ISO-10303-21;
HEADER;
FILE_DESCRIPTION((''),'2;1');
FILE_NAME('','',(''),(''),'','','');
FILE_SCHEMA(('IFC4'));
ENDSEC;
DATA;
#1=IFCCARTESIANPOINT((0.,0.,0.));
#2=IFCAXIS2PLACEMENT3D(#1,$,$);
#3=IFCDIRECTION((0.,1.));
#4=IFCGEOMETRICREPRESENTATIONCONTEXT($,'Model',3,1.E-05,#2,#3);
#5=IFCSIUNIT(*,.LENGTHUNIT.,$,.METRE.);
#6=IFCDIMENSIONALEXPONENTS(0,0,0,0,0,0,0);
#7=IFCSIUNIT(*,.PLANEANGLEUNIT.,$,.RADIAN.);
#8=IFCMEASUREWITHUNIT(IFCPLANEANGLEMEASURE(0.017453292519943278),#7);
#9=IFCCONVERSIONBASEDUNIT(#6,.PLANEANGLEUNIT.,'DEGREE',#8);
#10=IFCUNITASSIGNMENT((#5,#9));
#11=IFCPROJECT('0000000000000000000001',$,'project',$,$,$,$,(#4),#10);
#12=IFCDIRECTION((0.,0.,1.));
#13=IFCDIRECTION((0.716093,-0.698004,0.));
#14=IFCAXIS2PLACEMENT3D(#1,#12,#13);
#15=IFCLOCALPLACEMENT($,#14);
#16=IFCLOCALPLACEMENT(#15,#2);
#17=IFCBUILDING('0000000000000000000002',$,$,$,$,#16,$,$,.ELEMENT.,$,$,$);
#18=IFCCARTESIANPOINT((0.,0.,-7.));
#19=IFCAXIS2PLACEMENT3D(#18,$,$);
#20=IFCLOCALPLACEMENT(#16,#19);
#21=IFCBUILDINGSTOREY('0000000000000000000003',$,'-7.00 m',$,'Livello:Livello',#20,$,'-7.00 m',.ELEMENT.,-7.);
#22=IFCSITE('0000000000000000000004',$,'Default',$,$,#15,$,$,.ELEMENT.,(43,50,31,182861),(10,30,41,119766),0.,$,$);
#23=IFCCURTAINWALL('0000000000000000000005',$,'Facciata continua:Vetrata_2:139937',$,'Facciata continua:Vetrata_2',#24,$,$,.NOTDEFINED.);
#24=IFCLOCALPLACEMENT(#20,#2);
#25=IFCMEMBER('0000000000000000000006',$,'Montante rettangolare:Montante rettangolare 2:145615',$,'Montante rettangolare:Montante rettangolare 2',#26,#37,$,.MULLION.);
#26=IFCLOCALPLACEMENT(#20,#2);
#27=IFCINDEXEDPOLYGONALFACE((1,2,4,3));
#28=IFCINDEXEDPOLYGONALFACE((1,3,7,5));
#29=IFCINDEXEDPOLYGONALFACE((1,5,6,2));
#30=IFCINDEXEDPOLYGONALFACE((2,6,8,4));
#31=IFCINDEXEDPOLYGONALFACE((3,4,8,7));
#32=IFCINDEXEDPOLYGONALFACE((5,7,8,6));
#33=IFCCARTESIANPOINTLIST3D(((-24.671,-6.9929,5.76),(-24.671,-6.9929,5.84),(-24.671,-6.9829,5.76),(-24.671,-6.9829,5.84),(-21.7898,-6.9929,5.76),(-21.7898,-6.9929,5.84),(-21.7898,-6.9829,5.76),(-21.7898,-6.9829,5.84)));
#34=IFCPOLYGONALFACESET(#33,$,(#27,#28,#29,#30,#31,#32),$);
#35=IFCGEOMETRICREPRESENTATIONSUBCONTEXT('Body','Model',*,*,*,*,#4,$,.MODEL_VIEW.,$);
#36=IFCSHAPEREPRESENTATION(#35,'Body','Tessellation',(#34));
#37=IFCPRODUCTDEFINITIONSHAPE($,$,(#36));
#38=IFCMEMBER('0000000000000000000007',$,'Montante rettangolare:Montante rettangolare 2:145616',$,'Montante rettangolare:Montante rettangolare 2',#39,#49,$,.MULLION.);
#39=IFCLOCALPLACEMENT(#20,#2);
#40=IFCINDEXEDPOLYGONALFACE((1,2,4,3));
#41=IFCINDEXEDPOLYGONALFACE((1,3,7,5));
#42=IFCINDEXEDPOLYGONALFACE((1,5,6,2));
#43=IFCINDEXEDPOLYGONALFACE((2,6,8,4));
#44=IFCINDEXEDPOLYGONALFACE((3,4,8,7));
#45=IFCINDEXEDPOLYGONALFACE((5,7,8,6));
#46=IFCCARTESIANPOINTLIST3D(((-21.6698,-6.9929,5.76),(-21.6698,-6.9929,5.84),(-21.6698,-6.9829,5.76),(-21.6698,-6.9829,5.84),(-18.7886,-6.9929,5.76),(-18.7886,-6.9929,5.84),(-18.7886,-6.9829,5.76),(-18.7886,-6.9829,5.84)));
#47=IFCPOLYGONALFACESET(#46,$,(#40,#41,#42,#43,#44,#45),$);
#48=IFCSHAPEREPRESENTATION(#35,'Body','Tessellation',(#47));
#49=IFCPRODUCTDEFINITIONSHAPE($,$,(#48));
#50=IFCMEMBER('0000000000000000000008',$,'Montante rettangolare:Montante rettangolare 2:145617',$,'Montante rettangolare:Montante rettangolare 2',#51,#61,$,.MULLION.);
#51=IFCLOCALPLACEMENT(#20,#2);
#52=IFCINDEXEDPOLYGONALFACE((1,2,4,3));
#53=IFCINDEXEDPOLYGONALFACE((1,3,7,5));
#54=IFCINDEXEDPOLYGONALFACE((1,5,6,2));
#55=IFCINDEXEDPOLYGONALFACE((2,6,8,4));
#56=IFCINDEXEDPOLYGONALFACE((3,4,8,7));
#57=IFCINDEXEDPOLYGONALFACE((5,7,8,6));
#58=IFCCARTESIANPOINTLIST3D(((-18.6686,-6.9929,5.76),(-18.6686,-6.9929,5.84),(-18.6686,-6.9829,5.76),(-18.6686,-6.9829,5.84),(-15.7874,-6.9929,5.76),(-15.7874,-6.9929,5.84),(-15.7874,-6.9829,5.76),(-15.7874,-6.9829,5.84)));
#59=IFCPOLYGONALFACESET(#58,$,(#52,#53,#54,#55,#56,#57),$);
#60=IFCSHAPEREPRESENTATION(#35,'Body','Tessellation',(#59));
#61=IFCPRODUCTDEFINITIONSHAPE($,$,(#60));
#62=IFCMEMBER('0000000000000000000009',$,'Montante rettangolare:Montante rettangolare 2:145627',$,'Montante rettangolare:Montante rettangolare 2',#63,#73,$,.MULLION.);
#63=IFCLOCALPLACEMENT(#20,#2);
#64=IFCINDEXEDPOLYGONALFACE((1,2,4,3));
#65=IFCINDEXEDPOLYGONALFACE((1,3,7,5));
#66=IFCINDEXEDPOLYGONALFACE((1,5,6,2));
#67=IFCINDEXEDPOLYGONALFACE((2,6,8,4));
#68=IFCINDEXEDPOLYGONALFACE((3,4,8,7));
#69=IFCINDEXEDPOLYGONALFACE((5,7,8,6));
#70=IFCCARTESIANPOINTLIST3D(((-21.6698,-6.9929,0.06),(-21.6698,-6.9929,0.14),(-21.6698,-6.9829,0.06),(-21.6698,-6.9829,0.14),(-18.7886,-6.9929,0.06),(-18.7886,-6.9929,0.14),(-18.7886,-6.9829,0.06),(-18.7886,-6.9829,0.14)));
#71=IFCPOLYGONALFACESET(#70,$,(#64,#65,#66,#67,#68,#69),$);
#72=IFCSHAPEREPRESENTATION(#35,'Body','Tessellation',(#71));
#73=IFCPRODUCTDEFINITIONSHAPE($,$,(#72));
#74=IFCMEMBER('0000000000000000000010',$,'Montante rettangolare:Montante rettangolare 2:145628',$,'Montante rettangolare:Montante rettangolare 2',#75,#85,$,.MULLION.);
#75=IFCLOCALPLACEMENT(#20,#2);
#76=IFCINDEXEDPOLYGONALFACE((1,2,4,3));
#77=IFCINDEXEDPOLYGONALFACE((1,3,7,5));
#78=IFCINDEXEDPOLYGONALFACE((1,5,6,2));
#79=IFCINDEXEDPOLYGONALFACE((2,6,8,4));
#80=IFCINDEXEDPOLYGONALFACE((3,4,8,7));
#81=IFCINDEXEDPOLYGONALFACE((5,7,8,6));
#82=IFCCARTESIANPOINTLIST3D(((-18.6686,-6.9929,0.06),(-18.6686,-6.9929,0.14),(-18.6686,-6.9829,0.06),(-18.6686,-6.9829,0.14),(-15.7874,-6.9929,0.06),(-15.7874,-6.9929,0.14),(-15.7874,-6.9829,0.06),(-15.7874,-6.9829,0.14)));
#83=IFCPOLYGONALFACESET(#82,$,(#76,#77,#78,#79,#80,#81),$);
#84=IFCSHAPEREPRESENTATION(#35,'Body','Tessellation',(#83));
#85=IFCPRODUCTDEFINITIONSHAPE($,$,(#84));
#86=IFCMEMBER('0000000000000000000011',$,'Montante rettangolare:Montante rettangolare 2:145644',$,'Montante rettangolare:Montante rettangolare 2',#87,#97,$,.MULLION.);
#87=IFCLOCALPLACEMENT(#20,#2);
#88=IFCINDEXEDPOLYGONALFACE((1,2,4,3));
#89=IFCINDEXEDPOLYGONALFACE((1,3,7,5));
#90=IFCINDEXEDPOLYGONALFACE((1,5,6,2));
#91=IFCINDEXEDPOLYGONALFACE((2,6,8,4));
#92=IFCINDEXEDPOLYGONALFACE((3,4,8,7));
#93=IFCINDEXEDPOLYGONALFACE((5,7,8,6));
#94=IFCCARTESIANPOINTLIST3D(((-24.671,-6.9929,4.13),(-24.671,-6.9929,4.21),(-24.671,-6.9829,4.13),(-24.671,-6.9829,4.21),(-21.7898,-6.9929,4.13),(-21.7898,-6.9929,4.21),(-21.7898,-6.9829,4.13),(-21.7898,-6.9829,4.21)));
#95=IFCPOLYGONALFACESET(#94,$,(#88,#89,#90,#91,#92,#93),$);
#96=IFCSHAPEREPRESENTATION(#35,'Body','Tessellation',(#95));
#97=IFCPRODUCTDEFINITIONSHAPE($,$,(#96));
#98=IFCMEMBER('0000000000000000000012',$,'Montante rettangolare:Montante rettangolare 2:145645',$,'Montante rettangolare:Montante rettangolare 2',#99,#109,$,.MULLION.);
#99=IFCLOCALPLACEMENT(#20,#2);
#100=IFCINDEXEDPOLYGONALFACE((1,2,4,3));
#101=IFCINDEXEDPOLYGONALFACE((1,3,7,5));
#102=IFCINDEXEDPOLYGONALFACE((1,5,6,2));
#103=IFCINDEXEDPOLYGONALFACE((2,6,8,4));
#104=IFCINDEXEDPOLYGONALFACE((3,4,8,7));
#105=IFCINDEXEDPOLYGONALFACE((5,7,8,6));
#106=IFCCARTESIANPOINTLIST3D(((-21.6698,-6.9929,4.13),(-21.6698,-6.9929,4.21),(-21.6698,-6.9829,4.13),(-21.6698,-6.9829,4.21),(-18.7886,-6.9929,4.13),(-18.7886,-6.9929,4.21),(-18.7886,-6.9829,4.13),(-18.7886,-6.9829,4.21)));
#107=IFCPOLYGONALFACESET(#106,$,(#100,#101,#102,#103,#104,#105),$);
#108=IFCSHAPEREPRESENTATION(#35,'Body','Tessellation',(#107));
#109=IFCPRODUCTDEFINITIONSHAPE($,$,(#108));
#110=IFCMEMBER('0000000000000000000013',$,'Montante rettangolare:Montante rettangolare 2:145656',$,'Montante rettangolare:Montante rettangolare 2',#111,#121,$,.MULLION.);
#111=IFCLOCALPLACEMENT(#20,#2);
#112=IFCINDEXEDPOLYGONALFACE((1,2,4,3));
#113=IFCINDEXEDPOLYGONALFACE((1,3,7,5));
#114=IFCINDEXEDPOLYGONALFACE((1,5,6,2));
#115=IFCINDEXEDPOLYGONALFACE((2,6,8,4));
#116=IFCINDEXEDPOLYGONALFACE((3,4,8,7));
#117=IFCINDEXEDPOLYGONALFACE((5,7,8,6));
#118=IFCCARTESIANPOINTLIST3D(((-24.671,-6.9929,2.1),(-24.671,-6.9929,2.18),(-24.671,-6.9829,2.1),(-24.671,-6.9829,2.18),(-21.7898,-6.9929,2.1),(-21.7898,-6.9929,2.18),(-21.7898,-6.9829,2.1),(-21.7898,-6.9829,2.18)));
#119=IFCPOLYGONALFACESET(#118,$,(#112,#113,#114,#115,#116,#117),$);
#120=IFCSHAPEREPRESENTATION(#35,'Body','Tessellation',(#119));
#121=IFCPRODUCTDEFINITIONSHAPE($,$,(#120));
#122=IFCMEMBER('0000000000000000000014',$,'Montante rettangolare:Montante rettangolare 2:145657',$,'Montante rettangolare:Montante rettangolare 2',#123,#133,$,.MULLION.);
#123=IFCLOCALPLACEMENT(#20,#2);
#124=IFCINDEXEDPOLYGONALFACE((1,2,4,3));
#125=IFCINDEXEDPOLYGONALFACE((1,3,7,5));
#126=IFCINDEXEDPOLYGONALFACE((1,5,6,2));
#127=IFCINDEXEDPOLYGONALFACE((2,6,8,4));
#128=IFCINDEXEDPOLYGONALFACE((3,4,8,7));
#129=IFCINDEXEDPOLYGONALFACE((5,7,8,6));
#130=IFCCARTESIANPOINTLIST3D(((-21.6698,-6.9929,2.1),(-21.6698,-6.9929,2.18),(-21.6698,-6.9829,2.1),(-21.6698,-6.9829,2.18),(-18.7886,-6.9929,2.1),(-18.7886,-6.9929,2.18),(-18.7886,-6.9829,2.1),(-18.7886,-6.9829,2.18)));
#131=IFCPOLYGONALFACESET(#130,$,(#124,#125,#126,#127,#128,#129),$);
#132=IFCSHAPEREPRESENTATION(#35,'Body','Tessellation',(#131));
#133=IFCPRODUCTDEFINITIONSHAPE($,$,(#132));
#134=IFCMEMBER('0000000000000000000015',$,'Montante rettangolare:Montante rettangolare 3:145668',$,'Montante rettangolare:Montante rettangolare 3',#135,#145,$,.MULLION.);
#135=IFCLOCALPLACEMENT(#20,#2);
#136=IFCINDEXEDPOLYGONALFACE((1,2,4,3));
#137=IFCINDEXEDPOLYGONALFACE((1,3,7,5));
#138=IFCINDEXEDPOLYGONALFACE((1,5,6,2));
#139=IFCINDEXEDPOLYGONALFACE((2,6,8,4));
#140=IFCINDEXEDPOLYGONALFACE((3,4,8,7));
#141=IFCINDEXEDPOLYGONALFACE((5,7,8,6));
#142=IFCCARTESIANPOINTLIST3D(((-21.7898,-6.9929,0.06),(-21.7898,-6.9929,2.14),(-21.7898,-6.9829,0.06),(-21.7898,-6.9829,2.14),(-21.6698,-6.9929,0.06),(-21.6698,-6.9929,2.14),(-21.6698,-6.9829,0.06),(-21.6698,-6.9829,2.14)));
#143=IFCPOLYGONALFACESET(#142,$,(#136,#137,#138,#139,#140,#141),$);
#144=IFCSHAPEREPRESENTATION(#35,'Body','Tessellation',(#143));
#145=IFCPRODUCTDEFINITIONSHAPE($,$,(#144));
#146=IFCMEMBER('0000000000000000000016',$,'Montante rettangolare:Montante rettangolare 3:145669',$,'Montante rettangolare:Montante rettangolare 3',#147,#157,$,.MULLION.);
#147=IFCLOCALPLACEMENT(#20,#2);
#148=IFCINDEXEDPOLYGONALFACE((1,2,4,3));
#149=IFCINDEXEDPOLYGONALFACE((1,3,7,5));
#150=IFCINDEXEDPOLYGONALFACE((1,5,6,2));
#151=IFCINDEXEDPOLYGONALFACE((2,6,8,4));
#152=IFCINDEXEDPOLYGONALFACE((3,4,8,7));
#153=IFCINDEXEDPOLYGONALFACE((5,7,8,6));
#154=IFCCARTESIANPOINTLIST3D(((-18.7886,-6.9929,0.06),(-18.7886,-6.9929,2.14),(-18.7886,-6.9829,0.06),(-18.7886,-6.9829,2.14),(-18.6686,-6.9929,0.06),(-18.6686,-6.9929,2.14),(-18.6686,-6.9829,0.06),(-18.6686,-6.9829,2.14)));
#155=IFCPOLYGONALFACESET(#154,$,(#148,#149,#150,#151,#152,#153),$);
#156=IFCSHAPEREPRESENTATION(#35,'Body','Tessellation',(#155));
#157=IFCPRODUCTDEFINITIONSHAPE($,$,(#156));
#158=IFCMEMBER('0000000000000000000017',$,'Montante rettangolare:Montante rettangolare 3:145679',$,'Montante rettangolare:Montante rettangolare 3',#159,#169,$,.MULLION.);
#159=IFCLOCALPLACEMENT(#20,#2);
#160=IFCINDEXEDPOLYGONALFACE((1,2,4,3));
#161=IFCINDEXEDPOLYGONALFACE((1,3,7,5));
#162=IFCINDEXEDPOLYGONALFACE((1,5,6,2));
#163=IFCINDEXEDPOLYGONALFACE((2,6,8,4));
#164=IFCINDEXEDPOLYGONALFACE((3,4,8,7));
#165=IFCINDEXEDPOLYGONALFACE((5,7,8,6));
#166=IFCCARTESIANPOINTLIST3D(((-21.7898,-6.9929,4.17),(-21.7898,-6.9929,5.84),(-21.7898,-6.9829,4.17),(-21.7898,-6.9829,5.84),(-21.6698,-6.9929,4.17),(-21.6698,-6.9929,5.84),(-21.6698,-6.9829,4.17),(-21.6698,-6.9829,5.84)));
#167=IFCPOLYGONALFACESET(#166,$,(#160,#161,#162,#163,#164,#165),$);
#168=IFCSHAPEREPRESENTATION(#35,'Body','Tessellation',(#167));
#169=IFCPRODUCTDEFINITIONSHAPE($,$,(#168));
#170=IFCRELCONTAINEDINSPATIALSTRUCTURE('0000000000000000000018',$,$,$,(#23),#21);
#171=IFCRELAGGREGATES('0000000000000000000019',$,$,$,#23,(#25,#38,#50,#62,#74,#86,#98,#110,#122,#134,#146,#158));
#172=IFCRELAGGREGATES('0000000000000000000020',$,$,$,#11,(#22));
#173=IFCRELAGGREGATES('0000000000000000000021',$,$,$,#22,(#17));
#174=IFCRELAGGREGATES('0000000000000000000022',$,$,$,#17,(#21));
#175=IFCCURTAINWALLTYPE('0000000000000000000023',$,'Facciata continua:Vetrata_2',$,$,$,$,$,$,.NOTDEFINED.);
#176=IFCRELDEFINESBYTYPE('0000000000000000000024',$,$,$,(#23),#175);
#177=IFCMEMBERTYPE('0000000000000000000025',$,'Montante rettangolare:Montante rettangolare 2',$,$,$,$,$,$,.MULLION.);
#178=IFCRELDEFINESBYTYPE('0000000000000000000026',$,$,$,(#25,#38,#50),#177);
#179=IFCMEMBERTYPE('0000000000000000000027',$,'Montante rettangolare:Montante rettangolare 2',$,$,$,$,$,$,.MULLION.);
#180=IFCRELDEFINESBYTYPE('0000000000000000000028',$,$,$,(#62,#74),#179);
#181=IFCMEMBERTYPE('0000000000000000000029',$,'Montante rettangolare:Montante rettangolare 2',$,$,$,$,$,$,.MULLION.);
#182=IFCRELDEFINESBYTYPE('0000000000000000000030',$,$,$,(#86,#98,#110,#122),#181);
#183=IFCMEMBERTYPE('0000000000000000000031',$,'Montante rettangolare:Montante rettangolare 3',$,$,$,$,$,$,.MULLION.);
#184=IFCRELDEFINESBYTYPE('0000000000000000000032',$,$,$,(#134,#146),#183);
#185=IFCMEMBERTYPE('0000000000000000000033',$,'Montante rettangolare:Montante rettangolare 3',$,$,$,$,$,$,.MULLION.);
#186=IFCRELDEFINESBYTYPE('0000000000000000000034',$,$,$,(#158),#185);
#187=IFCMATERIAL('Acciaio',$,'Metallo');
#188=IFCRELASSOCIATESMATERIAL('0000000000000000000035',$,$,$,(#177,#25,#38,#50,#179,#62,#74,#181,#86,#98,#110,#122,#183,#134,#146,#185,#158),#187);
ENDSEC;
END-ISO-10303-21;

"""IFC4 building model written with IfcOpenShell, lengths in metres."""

from ifc_helpers import new_model, entity, si_unit, converted_unit, direction, frame, origin, place, context, subcontext, project, spatial, indexed_curve, outline, extrude, source, transform, mapped, material, type_object, type_shapes, element, aggregate, save


model = new_model("IFC4")

# Units and contexts
model_context = context("Model", 3, precision=1e-05, world=origin(), true_north=direction((0.0, 1.0)))
body_context = subcontext(model_context, "Body", "Model", "MODEL_VIEW")
ifc_project = project(units=[si_unit("LENGTHUNIT", "METRE"), converted_unit("PLANEANGLEUNIT", "DEGREE", entity("IfcPlaneAngleMeasure", 0.017453292519943278), si_unit("PLANEANGLEUNIT", "RADIAN"), dimensions=[0, 0, 0, 0, 0, 0, 0])], contexts=[model_context])

# Site, building, storey
site_placement = place(None, frame((0.0, 0.0, 0.0), z_axis=(0.0, 0.0, 1.0), x_axis=(0.716093, -0.698004, 0.0)))
site = spatial("IfcSite", under=ifc_project, at=site_placement, Name="Default", CompositionType="ELEMENT", RefLatitude=(43, 50, 31, 182861), RefLongitude=(10, 30, 41, 119766), RefElevation=0.0)
building_placement = place(site_placement, origin())
building = spatial("IfcBuilding", under=site, at=building_placement, CompositionType="ELEMENT")
storey_placement = place(building_placement, frame((0.0, 0.0, -7.0)))
storey = spatial("IfcBuildingStorey", under=building, at=storey_placement, Name="-7.00 m", ObjectType="Livello:Livello", LongName="-7.00 m", CompositionType="ELEMENT", Elevation=-7.0)

# Curtain wall, members
curtain_wall_type = type_object("IfcCurtainWallType", Name="Facciata continua:Vetrata_2", PredefinedType="NOTDEFINED")
curtain_wall_placement = place(storey_placement, frame((0.0, 0.0, 7.0)))
curtain_wall = element("IfcCurtainWall", 1, at=curtain_wall_placement, inside=storey, type_object=curtain_wall_type, Name="Facciata continua:Vetrata_2:139937", ObjectType="Facciata continua:Vetrata_2", PredefinedType="NOTDEFINED")
ifc_material_1 = material(Name="Acciaio", Category="Metallo")
member_type_1 = type_object("IfcMemberType", Name="Montante rettangolare:Montante rettangolare 2", PredefinedType="MULLION", material=ifc_material_1)
shared_shape_1 = source(origin(), body_context, "Body", "SweptSolid", [
    extrude(outline(indexed_curve([(-0.04, -0.005), (0.04, -0.005), (0.04, 0.005), (-0.04, 0.005), (-0.04, -0.005)], self_intersect=False)), frame((-0.04, 0.01, -2.8812), z_axis=(0.0, 0.0, 1.0), x_axis=(-1.0, 0.0, 0.0)), (0.0, 0.0, 1.0), 2.8812),
])
type_shapes(member_type_1, [shared_shape_1])
member_1_placement = place(curtain_wall_placement, frame((-21.7898, -6.9779, -1.16), z_axis=(1.0, 0.0, 0.0), x_axis=(0.0, 0.0, 1.0)))
member_1 = element("IfcMember", 2, at=member_1_placement, type_object=member_type_1, material=ifc_material_1, Name="Montante rettangolare:Montante rettangolare 2:145615", ObjectType="Montante rettangolare:Montante rettangolare 2", PredefinedType="MULLION", context=body_context, shape_type="MappedRepresentation", body=[
    mapped(shared_shape_1, transform((0.0, 0.0, 0.0), scale=1.0)),
])
member_2_placement = place(curtain_wall_placement, frame((-18.7886, -6.9779, -1.16), z_axis=(1.0, 0.0, 0.0), x_axis=(0.0, 0.0, 1.0)))
member_2 = element("IfcMember", 3, at=member_2_placement, type_object=member_type_1, material=ifc_material_1, Name="Montante rettangolare:Montante rettangolare 2:145616", ObjectType="Montante rettangolare:Montante rettangolare 2", PredefinedType="MULLION", context=body_context, shape_type="MappedRepresentation", body=[
    mapped(shared_shape_1, transform((0.0, 0.0, 0.0), scale=1.0)),
])
member_3_placement = place(curtain_wall_placement, frame((-15.7874, -6.9779, -1.16), z_axis=(1.0, 0.0, 0.0), x_axis=(0.0, 0.0, 1.0)))
member_3 = element("IfcMember", 4, at=member_3_placement, type_object=member_type_1, material=ifc_material_1, Name="Montante rettangolare:Montante rettangolare 2:145617", ObjectType="Montante rettangolare:Montante rettangolare 2", PredefinedType="MULLION", context=body_context, shape_type="MappedRepresentation", body=[
    mapped(shared_shape_1, transform((0.0, 0.0, 0.0), scale=1.0)),
])
member_type_2 = type_object("IfcMemberType", Name="Montante rettangolare:Montante rettangolare 2", PredefinedType="MULLION", material=ifc_material_1)
shared_shape_2 = source(origin(), body_context, "Body", "SweptSolid", [
    extrude(outline(indexed_curve([(-0.04, -0.005), (0.04, -0.005), (0.04, 0.005), (-0.04, 0.005), (-0.04, -0.005)], self_intersect=False)), frame((-0.04, 0.01, -2.8812), z_axis=(0.0, 0.0, 1.0), x_axis=(-1.0, 0.0, 0.0)), (0.0, 0.0, 1.0), 2.8812),
])
type_shapes(member_type_2, [shared_shape_2])
member_4_placement = place(curtain_wall_placement, frame((-21.6698, -6.9779, -6.94), z_axis=(-1.0, 0.0, 0.0), x_axis=(0.0, 0.0, -1.0)))
member_4 = element("IfcMember", 5, at=member_4_placement, type_object=member_type_2, material=ifc_material_1, Name="Montante rettangolare:Montante rettangolare 2:145627", ObjectType="Montante rettangolare:Montante rettangolare 2", PredefinedType="MULLION", context=body_context, shape_type="MappedRepresentation", body=[
    mapped(shared_shape_2, transform((0.0, 0.0, 0.0), scale=1.0)),
])
member_5_placement = place(curtain_wall_placement, frame((-18.6686, -6.9779, -6.94), z_axis=(-1.0, 0.0, 0.0), x_axis=(0.0, 0.0, -1.0)))
member_5 = element("IfcMember", 6, at=member_5_placement, type_object=member_type_2, material=ifc_material_1, Name="Montante rettangolare:Montante rettangolare 2:145628", ObjectType="Montante rettangolare:Montante rettangolare 2", PredefinedType="MULLION", context=body_context, shape_type="MappedRepresentation", body=[
    mapped(shared_shape_2, transform((0.0, 0.0, 0.0), scale=1.0)),
])
member_type_3 = type_object("IfcMemberType", Name="Montante rettangolare:Montante rettangolare 2", PredefinedType="MULLION", material=ifc_material_1)
shared_shape_3 = source(origin(), body_context, "Body", "SweptSolid", [
    extrude(outline(indexed_curve([(-0.04, -0.005), (0.04, -0.005), (0.04, 0.005), (-0.04, 0.005), (-0.04, -0.005)], self_intersect=False)), frame((0.0, 0.01, -2.8812), z_axis=(0.0, 0.0, 1.0), x_axis=(-1.0, 0.0, 0.0)), (0.0, 0.0, 1.0), 2.8812),
])
type_shapes(member_type_3, [shared_shape_3])
member_6_placement = place(curtain_wall_placement, frame((-21.7898, -6.9779, -2.83), z_axis=(1.0, 0.0, 0.0), x_axis=(0.0, 0.0, 1.0)))
member_6 = element("IfcMember", 7, at=member_6_placement, type_object=member_type_3, material=ifc_material_1, Name="Montante rettangolare:Montante rettangolare 2:145644", ObjectType="Montante rettangolare:Montante rettangolare 2", PredefinedType="MULLION", context=body_context, shape_type="MappedRepresentation", body=[
    mapped(shared_shape_3, transform((0.0, 0.0, 0.0), scale=1.0)),
])
member_7_placement = place(curtain_wall_placement, frame((-18.7886, -6.9779, -2.83), z_axis=(1.0, 0.0, 0.0), x_axis=(0.0, 0.0, 1.0)))
member_7 = element("IfcMember", 8, at=member_7_placement, type_object=member_type_3, material=ifc_material_1, Name="Montante rettangolare:Montante rettangolare 2:145645", ObjectType="Montante rettangolare:Montante rettangolare 2", PredefinedType="MULLION", context=body_context, shape_type="MappedRepresentation", body=[
    mapped(shared_shape_3, transform((0.0, 0.0, 0.0), scale=1.0)),
])
member_8_placement = place(curtain_wall_placement, frame((-21.7898, -6.9779, -4.86), z_axis=(1.0, 0.0, 0.0), x_axis=(0.0, 0.0, 1.0)))
member_8 = element("IfcMember", 9, at=member_8_placement, type_object=member_type_3, material=ifc_material_1, Name="Montante rettangolare:Montante rettangolare 2:145656", ObjectType="Montante rettangolare:Montante rettangolare 2", PredefinedType="MULLION", context=body_context, shape_type="MappedRepresentation", body=[
    mapped(shared_shape_3, transform((0.0, 0.0, 0.0), scale=1.0)),
])
member_9_placement = place(curtain_wall_placement, frame((-18.7886, -6.9779, -4.86), z_axis=(1.0, 0.0, 0.0), x_axis=(0.0, 0.0, 1.0)))
member_9 = element("IfcMember", 10, at=member_9_placement, type_object=member_type_3, material=ifc_material_1, Name="Montante rettangolare:Montante rettangolare 2:145657", ObjectType="Montante rettangolare:Montante rettangolare 2", PredefinedType="MULLION", context=body_context, shape_type="MappedRepresentation", body=[
    mapped(shared_shape_3, transform((0.0, 0.0, 0.0), scale=1.0)),
])
member_type_4 = type_object("IfcMemberType", Name="Montante rettangolare:Montante rettangolare 3", PredefinedType="MULLION", material=ifc_material_1)
shared_shape_4 = source(origin(), body_context, "Body", "SweptSolid", [
    extrude(outline(indexed_curve([(-0.06, -0.005), (0.06, -0.005), (0.06, 0.005), (-0.06, 0.005), (-0.06, -0.005)], self_intersect=False)), frame((0.0, 0.01, -2.08), z_axis=(0.0, 0.0, 1.0), x_axis=(-1.0, 0.0, 0.0)), (0.0, 0.0, 1.0), 2.08),
])
type_shapes(member_type_4, [shared_shape_4])
member_10_placement = place(curtain_wall_placement, frame((-21.7298, -6.9779, -6.94), z_axis=(0.0, 0.0, -1.0), x_axis=(1.0, 0.0, 0.0)))
member_10 = element("IfcMember", 11, at=member_10_placement, type_object=member_type_4, material=ifc_material_1, Name="Montante rettangolare:Montante rettangolare 3:145668", ObjectType="Montante rettangolare:Montante rettangolare 3", PredefinedType="MULLION", context=body_context, shape_type="MappedRepresentation", body=[
    mapped(shared_shape_4, transform((0.0, 0.0, 0.0), scale=1.0)),
])
member_11_placement = place(curtain_wall_placement, frame((-18.7286, -6.9779, -6.94), z_axis=(0.0, 0.0, -1.0), x_axis=(1.0, 0.0, 0.0)))
member_11 = element("IfcMember", 12, at=member_11_placement, type_object=member_type_4, material=ifc_material_1, Name="Montante rettangolare:Montante rettangolare 3:145669", ObjectType="Montante rettangolare:Montante rettangolare 3", PredefinedType="MULLION", context=body_context, shape_type="MappedRepresentation", body=[
    mapped(shared_shape_4, transform((0.0, 0.0, 0.0), scale=1.0)),
])
member_type_5 = type_object("IfcMemberType", Name="Montante rettangolare:Montante rettangolare 3", PredefinedType="MULLION", material=ifc_material_1)
shared_shape_5 = source(origin(), body_context, "Body", "SweptSolid", [
    extrude(outline(indexed_curve([(-0.06, -0.005), (0.06, -0.005), (0.06, 0.005), (-0.06, 0.005), (-0.06, -0.005)], self_intersect=False)), frame((0.0, 0.01, -1.67), z_axis=(0.0, 0.0, 1.0), x_axis=(-1.0, 0.0, 0.0)), (0.0, 0.0, 1.0), 1.67),
])
type_shapes(member_type_5, [shared_shape_5])
member_12_placement = place(curtain_wall_placement, frame((-21.7298, -6.9779, -2.83), z_axis=(0.0, 0.0, -1.0), x_axis=(1.0, 0.0, 0.0)))
member_12 = element("IfcMember", 13, at=member_12_placement, type_object=member_type_5, material=ifc_material_1, Name="Montante rettangolare:Montante rettangolare 3:145679", ObjectType="Montante rettangolare:Montante rettangolare 3", PredefinedType="MULLION", context=body_context, shape_type="MappedRepresentation", body=[
    mapped(shared_shape_5, transform((0.0, 0.0, 0.0), scale=1.0)),
])
aggregate(curtain_wall, [member_1, member_2, member_3, member_4, member_5, member_6, member_7, member_8, member_9, member_10, member_11, member_12])

save(model, "model.ifc")
